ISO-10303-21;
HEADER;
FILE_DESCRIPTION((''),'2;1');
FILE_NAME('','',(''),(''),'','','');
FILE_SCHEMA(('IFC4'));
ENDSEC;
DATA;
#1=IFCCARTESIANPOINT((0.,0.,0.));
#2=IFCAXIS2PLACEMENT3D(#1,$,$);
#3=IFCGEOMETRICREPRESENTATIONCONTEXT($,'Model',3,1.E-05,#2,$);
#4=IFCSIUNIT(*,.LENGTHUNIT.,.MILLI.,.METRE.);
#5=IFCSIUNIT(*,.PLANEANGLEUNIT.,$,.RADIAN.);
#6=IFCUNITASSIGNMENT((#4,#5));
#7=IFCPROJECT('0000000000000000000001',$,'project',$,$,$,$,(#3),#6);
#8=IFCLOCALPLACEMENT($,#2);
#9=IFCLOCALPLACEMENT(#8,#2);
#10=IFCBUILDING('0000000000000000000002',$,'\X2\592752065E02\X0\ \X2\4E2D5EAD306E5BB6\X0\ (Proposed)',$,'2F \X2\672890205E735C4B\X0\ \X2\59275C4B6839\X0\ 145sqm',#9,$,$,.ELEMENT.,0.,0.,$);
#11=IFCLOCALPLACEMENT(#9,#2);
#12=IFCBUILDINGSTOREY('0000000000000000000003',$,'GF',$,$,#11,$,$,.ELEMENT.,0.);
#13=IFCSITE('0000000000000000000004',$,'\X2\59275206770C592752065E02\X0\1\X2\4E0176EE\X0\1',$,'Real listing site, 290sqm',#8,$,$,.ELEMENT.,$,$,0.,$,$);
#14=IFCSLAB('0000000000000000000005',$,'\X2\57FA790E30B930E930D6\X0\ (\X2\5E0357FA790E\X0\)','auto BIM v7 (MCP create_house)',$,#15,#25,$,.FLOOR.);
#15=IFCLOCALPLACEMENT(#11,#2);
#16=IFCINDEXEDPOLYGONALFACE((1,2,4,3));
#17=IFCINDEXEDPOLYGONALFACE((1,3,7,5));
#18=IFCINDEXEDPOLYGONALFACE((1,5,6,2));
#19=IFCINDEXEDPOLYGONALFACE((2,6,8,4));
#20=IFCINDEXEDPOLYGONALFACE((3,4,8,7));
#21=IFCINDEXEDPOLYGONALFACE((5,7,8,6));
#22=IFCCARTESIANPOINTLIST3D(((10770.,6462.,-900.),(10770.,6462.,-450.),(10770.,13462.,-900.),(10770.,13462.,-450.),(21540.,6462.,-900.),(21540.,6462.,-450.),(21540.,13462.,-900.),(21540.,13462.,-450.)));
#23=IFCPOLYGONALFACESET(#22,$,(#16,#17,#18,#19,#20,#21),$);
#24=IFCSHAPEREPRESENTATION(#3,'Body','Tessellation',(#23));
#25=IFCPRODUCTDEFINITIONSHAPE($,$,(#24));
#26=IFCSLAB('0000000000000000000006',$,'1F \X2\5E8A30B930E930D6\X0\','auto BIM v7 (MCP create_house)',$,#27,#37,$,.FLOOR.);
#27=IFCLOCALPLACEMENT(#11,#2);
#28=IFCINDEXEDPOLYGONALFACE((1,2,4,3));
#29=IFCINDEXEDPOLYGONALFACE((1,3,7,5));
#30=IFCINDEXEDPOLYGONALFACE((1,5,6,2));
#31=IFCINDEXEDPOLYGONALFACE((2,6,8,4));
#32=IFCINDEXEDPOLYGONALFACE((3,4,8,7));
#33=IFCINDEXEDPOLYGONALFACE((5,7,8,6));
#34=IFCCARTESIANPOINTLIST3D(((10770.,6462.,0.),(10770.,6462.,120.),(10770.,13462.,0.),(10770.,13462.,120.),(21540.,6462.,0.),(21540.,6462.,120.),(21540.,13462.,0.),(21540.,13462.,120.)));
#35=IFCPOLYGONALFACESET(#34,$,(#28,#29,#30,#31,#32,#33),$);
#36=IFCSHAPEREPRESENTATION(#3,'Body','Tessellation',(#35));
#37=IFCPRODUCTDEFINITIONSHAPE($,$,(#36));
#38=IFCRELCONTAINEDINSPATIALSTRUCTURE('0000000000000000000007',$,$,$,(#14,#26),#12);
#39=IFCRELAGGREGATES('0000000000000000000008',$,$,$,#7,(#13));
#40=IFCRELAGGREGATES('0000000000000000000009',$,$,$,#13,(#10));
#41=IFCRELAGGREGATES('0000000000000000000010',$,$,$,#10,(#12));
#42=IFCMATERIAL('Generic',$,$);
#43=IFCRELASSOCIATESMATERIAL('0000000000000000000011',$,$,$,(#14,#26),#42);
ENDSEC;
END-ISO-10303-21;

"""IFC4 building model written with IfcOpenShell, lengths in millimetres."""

from ifc_helpers import new_model, si_unit, frame, frame_2d, origin, place, context, project, spatial, rectangle, extrude, material, element, save


model = new_model("IFC4")

# Units and contexts
model_context = context("Model", 3, precision=1e-05, world=origin())
ifc_project = project(units=[si_unit("LENGTHUNIT", "METRE", prefix="MILLI"), si_unit("PLANEANGLEUNIT", "RADIAN")], contexts=[model_context])

# Site, building, storey
site_placement = place(None, origin())
site = spatial("IfcSite", under=ifc_project, at=site_placement, Name="大分県大分市1丁目1", ObjectType="Real listing site, 290sqm", CompositionType="ELEMENT", RefElevation=0.0)
building_placement = place(site_placement, origin())
building = spatial("IfcBuilding", under=site, at=building_placement, Name="大分市 中庭の家 (Proposed)", ObjectType="2F 木造平屋 大屋根 145sqm", CompositionType="ELEMENT", ElevationOfRefHeight=0.0, ElevationOfTerrain=0.0)
storey_placement = place(building_placement, origin())
storey = spatial("IfcBuildingStorey", under=building, at=storey_placement, Name="GF", CompositionType="ELEMENT", Elevation=0.0)

# Slabs
ifc_material = material(Name="Generic")
slab_1_placement = place(storey_placement, frame((5385.0, 3231.0, -450.0)))
element("IfcSlab", 1, at=slab_1_placement, inside=storey, material=ifc_material, Name="基礎スラブ (布基礎)", Description="auto BIM v7 (MCP create_house)", PredefinedType="FLOOR", context=model_context, shape_type="SweptSolid", body=[
    extrude(rectangle(XDim=10770.0, YDim=7000.0, at=frame_2d((5385.0, 3500.0))), frame((5385.0, 3231.0, -450.0)), (0.0, 0.0, 1.0), 450.0),
])
slab_2_placement = place(storey_placement, frame((5385.0, 3231.0, 0.0)))
element("IfcSlab", 2, at=slab_2_placement, inside=storey, material=ifc_material, Name="1F 床スラブ", Description="auto BIM v7 (MCP create_house)", PredefinedType="FLOOR", context=model_context, shape_type="SweptSolid", body=[
    extrude(rectangle(XDim=10770.0, YDim=7000.0, at=frame_2d((5385.0, 3500.0))), frame((5385.0, 3231.0, 0.0)), (0.0, 0.0, 1.0), 120.0),
])

save(model, "model.ifc")
